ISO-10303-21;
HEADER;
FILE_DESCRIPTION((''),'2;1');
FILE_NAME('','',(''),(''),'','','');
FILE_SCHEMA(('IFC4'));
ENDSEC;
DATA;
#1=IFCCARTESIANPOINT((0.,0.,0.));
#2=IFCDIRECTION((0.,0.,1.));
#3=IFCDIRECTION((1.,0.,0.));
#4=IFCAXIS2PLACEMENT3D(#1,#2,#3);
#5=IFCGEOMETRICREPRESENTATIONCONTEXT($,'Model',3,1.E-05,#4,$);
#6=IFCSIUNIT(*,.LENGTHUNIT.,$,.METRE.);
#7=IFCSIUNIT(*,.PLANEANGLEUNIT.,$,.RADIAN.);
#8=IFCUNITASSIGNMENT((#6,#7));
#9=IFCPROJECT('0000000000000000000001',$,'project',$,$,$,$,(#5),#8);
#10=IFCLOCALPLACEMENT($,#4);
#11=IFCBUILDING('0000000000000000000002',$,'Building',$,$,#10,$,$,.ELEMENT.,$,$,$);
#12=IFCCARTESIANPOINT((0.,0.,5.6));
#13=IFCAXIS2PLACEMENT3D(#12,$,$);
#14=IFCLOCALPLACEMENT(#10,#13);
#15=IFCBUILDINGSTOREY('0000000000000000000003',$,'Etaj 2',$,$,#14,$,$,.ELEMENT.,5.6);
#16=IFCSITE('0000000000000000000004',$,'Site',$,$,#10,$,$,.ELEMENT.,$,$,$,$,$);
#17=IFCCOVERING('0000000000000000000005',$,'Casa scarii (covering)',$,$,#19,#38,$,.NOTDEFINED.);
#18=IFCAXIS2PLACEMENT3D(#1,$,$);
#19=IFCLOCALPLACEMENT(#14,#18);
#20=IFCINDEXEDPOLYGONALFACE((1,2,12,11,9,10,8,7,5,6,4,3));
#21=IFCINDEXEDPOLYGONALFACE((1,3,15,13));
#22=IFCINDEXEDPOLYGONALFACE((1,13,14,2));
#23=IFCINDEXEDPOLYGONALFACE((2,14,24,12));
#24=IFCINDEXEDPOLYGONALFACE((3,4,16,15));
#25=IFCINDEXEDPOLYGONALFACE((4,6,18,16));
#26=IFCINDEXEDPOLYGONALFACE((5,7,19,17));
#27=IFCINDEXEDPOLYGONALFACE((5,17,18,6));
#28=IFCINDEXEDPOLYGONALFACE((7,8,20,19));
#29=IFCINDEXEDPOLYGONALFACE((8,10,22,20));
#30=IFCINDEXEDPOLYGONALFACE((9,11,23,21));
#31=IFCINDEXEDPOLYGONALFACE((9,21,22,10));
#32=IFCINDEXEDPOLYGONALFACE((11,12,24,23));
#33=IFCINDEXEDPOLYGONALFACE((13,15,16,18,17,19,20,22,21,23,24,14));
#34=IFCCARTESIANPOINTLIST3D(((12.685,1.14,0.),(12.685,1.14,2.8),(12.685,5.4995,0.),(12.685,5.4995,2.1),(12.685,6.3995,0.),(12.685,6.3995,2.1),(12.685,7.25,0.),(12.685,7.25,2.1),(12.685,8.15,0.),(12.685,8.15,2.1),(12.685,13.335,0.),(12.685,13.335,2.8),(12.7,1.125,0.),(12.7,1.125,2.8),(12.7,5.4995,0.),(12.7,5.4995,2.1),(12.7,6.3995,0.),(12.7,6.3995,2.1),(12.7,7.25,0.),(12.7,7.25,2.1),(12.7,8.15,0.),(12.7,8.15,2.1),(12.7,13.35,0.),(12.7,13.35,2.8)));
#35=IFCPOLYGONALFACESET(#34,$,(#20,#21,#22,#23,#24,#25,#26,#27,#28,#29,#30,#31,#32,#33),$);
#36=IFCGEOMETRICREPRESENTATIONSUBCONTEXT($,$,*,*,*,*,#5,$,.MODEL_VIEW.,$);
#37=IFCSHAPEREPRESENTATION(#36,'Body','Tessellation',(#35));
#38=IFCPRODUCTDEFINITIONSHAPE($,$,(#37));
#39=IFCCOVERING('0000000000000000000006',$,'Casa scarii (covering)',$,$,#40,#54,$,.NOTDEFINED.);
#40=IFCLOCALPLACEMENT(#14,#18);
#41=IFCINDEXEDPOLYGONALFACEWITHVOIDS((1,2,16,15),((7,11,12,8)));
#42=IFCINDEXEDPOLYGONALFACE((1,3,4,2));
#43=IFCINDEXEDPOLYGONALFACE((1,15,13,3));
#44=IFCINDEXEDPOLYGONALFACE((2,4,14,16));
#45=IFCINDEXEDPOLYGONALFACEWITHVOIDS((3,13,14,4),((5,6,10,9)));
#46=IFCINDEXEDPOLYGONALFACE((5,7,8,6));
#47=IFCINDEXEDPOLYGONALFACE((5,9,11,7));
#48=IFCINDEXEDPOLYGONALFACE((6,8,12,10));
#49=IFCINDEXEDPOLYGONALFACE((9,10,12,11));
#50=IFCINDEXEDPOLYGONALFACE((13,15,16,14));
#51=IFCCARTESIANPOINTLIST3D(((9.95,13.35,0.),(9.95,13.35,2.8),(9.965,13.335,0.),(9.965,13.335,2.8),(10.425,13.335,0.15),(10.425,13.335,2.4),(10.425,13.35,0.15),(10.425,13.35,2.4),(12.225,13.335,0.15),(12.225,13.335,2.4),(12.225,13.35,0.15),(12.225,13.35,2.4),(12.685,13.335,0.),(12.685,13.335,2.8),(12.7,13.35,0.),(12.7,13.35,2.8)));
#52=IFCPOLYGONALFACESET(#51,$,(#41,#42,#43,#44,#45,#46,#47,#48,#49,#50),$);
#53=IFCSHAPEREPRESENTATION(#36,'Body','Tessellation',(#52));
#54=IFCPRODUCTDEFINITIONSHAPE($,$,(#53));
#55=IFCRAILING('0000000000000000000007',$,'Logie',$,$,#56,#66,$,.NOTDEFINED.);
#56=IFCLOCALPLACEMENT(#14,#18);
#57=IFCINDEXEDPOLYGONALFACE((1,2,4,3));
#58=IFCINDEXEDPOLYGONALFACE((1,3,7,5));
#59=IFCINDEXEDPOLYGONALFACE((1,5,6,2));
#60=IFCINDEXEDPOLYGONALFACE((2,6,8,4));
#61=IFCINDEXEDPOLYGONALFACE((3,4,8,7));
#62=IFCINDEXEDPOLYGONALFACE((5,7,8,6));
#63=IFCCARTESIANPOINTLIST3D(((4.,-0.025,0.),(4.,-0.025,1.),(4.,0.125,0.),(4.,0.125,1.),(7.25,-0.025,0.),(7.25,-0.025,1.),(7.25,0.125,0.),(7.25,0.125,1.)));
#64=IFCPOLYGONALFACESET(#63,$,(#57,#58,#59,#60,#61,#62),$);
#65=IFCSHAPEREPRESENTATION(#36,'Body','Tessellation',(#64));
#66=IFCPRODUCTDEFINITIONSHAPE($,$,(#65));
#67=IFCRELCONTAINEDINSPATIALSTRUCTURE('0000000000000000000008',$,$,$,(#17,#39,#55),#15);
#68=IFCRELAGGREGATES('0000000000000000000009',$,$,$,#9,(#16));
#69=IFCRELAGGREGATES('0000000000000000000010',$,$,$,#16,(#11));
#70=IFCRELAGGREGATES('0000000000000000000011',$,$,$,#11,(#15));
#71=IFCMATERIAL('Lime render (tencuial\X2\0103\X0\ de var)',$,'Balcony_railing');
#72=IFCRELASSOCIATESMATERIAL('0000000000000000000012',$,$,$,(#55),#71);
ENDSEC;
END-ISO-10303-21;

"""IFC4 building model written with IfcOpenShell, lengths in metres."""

from ifc_helpers import new_model, si_unit, frame, origin, origin_with_axes, origin_2d, place, context, subcontext, project, spatial, polyline, rectangle, outline, extrude, material, element, save


model = new_model("IFC4")

# Units and contexts
model_context = context("Model", 3, precision=1e-05, world=origin_with_axes())
sub_context = subcontext(model_context, None, None, "MODEL_VIEW")
ifc_project = project(units=[si_unit("LENGTHUNIT", "METRE"), si_unit("PLANEANGLEUNIT", "RADIAN")], contexts=[model_context])

# Site, building, storey
placement = place(None, origin_with_axes())
site = spatial("IfcSite", under=ifc_project, at=placement, Name="Site", CompositionType="ELEMENT")
building = spatial("IfcBuilding", under=site, at=placement, Name="Building", CompositionType="ELEMENT")
storey_placement = place(placement, frame((0.0, 0.0, 5.6)))
storey = spatial("IfcBuildingStorey", under=building, at=storey_placement, Name="Etaj 2", CompositionType="ELEMENT", Elevation=5.6)

# Covering, openings
covering_1_placement = place(storey_placement, origin_with_axes())
covering_1 = element("IfcCovering", 1, at=covering_1_placement, inside=storey, Name="Casa scarii (covering)", PredefinedType="NOTDEFINED", context=sub_context, shape_type="SweptSolid", body=[
    extrude(outline(polyline([(12.7, 1.125), (12.7, 13.35), (12.685, 13.335), (12.685, 1.14), (12.7, 1.125)])), origin(), (0.0, 0.0, 1.0), 2.8),
])
opening_1_placement = place(covering_1_placement, frame((12.635, 5.9495, 0.0), z_axis=(1.0, 0.0, 0.0), x_axis=(0.0, 1.0, 0.0)))
element("IfcOpeningElement", 2, at=opening_1_placement, cuts=covering_1, PredefinedType="OPENING", context=sub_context, shape_type="SweptSolid", body=[
    extrude(rectangle(XDim=0.9, YDim=2.1, at=origin_2d()), frame((0.0, 1.05, 0.0)), (0.0, 0.0, 1.0), 0.38),
])
opening_2_placement = place(covering_1_placement, frame((12.635, 7.7, 0.0), z_axis=(1.0, 0.0, 0.0), x_axis=(0.0, 1.0, 0.0)))
element("IfcOpeningElement", 3, at=opening_2_placement, cuts=covering_1, PredefinedType="OPENING", context=sub_context, shape_type="SweptSolid", body=[
    extrude(rectangle(XDim=0.9, YDim=2.1, at=origin_2d()), frame((0.0, 1.05, 0.0)), (0.0, 0.0, 1.0), 0.38),
])

# Covering, opening
covering_2_placement = place(storey_placement, origin_with_axes())
covering_2 = element("IfcCovering", 4, at=covering_2_placement, inside=storey, Name="Casa scarii (covering)", PredefinedType="NOTDEFINED", context=sub_context, shape_type="SweptSolid", body=[
    extrude(outline(polyline([(12.7, 13.35), (9.95, 13.35), (9.965, 13.335), (12.685, 13.335), (12.7, 13.35)])), origin(), (0.0, 0.0, 1.0), 2.8),
])
opening_3_placement = place(covering_2_placement, frame((11.325, 13.665, 0.15), z_axis=(0.0, -1.0, 0.0), x_axis=(1.0, 0.0, 0.0)))
element("IfcOpeningElement", 5, at=opening_3_placement, cuts=covering_2, PredefinedType="OPENING", context=sub_context, shape_type="SweptSolid", body=[
    extrude(rectangle(XDim=1.8, YDim=2.25, at=origin_2d()), frame((0.0, 1.125, 0.0)), (0.0, 0.0, 1.0), 0.38),
])

# Railing
ifc_material = material(Name="Lime render (tencuială de var)", Category="Balcony_railing")
railing_placement = place(storey_placement, frame((4.0, -0.025, 0.0), z_axis=(0.0, 0.0, 1.0), x_axis=(1.0, 0.0, 0.0)))
element("IfcRailing", 6, at=railing_placement, inside=storey, material=ifc_material, Name="Logie", PredefinedType="NOTDEFINED", context=sub_context, shape_type="SweptSolid", body=[
    extrude(outline(polyline([(0.0, 0.0), (3.25, 0.0), (3.25, 0.15), (0.0, 0.15), (0.0, 0.0)])), origin(), (0.0, 0.0, 1.0), 1.0),
])

save(model, "model.ifc")
